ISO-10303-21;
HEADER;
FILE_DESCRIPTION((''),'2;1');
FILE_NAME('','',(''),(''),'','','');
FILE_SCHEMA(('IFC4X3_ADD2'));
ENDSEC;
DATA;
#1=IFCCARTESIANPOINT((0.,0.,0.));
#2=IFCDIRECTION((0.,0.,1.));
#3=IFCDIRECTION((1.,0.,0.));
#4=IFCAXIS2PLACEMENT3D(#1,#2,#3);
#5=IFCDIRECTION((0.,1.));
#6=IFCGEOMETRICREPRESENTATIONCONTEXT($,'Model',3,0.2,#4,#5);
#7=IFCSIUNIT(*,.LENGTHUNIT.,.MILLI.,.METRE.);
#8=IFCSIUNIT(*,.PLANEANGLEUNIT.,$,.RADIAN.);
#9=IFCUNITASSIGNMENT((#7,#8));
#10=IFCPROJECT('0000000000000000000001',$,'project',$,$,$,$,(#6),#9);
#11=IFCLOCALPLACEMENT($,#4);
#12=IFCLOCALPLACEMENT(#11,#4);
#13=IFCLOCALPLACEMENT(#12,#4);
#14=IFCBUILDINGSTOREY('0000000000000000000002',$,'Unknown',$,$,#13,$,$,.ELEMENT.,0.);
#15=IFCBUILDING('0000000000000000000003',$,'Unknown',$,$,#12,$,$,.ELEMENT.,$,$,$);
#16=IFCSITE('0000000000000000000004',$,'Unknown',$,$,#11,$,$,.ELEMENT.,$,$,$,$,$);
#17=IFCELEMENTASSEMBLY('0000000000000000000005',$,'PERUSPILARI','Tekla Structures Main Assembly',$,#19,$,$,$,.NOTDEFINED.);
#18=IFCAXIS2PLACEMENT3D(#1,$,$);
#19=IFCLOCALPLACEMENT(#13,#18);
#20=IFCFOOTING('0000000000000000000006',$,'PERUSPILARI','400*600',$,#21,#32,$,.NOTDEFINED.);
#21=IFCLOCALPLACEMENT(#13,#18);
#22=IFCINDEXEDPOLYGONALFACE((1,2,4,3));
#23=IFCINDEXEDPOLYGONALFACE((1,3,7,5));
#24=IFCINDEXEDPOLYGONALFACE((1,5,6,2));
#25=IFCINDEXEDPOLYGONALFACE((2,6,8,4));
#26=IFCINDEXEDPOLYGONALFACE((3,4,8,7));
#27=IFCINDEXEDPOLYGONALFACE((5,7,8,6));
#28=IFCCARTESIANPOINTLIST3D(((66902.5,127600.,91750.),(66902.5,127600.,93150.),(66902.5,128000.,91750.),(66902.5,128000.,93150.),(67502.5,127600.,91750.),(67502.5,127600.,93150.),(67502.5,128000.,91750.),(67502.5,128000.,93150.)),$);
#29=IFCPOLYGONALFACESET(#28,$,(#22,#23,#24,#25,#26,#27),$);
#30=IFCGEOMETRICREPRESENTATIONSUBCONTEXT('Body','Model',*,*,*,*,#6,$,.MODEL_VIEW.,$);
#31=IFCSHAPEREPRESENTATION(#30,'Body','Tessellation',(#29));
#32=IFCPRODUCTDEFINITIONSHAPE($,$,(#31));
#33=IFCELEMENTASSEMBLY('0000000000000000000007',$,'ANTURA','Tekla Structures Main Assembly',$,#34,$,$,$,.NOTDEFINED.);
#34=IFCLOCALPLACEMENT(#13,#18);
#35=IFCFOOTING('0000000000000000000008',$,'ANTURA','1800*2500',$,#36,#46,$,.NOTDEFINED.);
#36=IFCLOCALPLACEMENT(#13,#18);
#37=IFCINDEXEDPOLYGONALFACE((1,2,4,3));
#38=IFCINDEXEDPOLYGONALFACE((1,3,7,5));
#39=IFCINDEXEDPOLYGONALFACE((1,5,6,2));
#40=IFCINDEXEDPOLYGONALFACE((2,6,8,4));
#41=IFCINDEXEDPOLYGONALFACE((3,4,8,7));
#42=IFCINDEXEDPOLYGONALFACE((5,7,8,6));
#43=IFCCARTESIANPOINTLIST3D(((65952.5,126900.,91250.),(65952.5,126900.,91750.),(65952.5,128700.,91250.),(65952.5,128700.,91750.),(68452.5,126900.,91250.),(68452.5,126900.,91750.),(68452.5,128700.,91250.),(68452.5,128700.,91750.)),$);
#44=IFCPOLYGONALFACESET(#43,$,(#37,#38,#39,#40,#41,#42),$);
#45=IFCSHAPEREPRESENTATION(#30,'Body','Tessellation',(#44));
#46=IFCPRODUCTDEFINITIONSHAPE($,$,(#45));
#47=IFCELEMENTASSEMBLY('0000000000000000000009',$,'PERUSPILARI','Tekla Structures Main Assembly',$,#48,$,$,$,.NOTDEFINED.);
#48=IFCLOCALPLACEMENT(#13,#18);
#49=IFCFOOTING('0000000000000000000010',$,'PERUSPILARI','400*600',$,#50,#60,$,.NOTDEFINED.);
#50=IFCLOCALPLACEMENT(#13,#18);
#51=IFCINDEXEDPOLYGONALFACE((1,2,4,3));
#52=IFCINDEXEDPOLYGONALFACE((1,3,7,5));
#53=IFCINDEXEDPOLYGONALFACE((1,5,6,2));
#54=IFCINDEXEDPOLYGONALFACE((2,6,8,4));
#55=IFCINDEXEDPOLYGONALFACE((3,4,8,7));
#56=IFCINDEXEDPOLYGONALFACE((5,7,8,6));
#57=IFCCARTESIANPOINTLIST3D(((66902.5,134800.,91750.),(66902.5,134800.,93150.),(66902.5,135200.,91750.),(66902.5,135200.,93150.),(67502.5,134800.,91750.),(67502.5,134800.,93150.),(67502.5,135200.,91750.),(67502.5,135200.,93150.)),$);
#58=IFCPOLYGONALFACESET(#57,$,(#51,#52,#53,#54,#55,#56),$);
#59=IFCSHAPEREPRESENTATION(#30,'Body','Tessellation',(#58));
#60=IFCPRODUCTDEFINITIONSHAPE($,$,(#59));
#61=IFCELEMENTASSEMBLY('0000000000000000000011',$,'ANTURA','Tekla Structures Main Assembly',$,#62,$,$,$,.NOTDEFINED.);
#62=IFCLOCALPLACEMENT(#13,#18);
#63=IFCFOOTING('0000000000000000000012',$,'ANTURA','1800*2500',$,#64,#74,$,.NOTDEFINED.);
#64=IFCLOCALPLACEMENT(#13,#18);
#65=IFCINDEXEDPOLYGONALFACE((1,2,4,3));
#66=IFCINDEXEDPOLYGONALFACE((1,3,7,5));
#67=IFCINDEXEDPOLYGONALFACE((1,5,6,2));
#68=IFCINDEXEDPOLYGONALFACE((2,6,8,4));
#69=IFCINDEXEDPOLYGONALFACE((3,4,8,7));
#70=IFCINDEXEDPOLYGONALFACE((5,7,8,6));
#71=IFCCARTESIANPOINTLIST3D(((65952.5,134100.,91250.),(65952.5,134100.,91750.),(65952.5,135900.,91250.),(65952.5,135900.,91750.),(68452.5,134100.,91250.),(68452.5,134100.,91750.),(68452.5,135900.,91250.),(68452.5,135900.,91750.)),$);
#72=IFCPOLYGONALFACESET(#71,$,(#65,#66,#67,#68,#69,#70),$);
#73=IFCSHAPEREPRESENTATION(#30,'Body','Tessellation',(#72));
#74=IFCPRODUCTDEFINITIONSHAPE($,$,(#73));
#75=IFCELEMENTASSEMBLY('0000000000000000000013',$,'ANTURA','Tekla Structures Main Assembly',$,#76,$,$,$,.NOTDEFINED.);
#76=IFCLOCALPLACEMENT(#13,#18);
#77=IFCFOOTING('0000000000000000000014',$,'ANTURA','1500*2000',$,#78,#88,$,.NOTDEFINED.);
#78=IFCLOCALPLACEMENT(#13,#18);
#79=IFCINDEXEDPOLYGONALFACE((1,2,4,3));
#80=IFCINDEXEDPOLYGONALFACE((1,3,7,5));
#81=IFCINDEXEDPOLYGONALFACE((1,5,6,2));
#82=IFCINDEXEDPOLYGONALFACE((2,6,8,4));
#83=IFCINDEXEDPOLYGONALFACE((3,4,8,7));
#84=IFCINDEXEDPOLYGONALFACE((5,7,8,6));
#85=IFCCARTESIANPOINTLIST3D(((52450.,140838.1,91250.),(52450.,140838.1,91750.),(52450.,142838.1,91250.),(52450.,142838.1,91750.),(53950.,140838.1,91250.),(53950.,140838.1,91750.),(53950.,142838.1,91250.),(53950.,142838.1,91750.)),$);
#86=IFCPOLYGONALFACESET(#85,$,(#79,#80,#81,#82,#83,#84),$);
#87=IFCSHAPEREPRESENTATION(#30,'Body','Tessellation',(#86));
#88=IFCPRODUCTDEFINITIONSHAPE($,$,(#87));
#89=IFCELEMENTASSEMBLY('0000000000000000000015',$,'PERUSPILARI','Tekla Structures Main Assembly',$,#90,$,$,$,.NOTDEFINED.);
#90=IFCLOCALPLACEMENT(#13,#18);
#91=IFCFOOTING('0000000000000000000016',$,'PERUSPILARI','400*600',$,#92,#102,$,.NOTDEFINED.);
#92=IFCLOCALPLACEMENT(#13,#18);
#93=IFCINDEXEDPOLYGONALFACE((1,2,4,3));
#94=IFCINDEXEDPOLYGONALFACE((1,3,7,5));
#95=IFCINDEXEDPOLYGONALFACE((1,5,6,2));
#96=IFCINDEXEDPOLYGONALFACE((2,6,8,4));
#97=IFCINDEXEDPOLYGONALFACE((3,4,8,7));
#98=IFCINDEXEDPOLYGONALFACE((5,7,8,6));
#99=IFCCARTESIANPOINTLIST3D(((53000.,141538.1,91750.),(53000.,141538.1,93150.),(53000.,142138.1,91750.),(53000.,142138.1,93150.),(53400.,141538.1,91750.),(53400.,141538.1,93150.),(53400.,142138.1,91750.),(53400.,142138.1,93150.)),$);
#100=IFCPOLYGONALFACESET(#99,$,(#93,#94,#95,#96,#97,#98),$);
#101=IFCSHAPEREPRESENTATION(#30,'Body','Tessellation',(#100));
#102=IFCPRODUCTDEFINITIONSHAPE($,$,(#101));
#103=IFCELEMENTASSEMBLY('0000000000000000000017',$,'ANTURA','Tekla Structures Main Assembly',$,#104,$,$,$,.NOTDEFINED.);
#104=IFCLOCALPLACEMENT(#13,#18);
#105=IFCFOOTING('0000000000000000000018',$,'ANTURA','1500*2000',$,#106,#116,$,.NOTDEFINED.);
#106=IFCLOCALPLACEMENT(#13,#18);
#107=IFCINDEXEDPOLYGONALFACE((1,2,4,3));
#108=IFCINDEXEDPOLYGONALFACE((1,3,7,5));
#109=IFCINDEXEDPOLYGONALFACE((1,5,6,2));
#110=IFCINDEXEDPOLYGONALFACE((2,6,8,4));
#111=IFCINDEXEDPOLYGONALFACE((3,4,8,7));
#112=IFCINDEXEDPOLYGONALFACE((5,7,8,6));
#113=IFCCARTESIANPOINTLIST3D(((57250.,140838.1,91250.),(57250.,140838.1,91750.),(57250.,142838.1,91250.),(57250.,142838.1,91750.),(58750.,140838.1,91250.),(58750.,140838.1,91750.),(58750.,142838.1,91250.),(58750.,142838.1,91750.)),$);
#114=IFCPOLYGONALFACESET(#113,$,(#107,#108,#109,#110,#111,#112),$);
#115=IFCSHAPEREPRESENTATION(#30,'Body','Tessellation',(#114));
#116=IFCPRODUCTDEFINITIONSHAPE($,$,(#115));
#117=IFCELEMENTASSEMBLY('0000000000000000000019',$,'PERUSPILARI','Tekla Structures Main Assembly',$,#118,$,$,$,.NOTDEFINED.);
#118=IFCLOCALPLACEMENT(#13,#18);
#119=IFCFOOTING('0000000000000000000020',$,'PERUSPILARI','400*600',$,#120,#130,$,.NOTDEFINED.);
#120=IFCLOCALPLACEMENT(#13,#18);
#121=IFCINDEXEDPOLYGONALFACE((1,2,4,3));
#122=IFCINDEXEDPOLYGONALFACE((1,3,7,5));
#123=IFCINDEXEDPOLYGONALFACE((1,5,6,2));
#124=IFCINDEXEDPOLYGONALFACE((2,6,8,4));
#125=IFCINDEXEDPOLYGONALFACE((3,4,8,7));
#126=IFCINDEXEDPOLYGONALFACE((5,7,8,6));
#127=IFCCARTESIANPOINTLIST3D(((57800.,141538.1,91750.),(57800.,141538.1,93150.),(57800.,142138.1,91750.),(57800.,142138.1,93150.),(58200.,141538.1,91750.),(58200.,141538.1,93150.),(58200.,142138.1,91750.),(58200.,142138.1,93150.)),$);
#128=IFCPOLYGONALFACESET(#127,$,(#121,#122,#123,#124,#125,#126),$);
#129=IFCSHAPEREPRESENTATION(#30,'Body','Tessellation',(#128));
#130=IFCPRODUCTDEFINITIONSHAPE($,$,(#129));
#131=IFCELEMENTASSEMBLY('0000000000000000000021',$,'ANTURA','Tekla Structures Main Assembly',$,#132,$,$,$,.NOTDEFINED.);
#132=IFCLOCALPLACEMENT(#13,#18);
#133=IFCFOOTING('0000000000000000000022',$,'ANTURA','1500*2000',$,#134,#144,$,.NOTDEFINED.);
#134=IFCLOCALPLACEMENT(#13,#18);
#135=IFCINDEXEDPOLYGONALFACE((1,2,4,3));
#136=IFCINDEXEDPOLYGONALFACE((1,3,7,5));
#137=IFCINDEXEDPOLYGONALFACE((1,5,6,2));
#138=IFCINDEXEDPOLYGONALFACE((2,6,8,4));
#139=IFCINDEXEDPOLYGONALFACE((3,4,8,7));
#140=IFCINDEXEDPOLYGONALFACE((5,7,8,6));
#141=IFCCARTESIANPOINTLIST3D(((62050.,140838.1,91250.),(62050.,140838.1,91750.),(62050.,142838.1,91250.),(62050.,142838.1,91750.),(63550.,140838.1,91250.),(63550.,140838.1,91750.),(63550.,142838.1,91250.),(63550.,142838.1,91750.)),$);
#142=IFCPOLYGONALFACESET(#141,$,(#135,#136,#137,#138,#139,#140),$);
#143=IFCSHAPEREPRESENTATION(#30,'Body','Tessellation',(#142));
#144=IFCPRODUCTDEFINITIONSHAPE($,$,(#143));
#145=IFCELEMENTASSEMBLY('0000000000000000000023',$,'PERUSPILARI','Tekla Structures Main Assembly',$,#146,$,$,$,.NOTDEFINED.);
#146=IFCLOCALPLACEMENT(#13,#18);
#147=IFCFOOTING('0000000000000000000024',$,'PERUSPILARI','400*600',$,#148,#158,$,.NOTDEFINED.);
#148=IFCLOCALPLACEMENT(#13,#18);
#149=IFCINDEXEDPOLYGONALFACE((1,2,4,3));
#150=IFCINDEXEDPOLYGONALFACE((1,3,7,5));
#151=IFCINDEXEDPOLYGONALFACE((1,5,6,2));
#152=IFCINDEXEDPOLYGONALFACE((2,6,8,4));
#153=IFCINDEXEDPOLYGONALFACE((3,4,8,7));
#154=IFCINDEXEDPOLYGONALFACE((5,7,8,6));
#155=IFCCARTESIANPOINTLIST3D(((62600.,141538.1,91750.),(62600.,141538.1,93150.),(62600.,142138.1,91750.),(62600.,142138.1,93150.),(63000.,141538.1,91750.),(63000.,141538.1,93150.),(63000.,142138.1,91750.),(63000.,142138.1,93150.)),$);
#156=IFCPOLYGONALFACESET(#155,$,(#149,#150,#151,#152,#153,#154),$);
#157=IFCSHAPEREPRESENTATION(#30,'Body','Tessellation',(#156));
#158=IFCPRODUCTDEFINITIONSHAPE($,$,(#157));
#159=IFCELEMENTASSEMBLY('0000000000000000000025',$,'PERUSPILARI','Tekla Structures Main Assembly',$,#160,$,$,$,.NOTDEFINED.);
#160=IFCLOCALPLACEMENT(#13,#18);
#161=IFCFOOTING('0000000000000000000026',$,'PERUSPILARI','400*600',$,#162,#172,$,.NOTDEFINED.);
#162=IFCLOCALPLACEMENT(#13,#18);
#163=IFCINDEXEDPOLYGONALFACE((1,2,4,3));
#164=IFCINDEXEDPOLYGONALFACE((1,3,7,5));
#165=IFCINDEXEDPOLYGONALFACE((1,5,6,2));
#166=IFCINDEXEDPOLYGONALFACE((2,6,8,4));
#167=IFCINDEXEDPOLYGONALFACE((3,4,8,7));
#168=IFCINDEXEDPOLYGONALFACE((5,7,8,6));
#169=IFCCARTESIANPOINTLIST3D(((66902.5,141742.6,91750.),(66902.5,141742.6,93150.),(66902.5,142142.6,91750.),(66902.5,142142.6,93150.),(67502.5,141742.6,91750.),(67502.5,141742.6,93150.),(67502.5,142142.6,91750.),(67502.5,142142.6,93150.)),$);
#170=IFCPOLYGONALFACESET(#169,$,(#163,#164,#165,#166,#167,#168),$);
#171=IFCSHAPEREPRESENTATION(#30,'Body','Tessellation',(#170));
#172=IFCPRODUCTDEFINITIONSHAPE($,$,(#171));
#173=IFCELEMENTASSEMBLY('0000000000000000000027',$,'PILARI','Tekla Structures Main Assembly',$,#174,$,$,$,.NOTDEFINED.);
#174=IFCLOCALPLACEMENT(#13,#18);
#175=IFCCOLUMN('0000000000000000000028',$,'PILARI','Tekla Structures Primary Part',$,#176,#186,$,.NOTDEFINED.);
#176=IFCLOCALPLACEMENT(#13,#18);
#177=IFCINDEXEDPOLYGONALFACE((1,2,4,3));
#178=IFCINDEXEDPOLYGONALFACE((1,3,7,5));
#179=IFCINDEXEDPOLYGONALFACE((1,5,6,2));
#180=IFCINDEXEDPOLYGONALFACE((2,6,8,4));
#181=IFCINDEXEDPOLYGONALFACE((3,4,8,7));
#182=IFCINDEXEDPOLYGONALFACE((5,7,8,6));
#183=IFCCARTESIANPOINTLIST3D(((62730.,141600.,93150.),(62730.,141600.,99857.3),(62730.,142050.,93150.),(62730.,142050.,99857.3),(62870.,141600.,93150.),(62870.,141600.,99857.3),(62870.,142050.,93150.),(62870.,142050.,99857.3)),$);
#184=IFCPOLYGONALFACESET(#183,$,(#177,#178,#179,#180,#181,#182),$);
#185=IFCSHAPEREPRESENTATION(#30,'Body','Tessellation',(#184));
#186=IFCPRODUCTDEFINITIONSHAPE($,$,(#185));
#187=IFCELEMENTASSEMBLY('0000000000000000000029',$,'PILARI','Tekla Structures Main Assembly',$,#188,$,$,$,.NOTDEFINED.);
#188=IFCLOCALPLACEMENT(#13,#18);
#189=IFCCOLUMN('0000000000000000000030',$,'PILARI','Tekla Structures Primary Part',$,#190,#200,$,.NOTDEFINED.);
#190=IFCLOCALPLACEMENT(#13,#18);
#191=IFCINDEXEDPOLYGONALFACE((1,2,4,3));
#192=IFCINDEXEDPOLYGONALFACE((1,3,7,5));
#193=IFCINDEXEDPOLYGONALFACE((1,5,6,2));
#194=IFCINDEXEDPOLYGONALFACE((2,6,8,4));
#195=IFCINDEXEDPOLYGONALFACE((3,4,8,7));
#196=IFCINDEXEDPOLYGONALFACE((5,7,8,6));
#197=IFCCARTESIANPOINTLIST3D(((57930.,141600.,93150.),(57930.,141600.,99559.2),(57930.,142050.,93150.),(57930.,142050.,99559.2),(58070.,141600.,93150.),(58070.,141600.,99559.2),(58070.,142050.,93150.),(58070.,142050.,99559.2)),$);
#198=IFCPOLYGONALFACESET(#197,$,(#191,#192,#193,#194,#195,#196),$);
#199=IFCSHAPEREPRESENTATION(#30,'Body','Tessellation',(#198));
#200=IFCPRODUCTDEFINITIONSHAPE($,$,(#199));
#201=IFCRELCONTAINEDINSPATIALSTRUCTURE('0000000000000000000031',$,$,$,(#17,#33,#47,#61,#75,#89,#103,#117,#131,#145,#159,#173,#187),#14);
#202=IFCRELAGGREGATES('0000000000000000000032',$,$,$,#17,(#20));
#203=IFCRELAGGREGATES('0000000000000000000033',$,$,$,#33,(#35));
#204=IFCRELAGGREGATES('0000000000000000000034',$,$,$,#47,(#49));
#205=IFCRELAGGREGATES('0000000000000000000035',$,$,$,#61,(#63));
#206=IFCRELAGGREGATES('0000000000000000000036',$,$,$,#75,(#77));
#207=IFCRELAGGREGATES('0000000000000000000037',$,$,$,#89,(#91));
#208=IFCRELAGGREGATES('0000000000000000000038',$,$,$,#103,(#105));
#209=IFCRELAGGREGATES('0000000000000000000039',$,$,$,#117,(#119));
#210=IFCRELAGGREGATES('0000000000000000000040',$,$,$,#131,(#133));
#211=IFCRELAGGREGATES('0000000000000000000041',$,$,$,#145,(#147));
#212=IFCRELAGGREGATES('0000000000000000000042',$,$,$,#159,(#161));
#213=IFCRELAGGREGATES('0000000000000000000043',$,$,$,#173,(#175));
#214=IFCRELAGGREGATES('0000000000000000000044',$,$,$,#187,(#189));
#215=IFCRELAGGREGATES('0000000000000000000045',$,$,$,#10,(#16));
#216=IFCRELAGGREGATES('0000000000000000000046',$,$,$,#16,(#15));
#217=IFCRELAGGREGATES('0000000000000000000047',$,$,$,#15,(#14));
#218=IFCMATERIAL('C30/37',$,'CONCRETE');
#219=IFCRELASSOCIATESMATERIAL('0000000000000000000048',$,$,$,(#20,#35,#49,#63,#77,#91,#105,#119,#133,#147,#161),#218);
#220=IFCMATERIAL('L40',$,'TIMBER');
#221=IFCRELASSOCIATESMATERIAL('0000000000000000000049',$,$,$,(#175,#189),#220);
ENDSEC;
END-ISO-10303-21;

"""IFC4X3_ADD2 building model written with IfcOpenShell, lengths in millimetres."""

from ifc_helpers import new_model, si_unit, direction, frame, origin_with_axes, place, context, subcontext, project, spatial, line, indexed_curve, outline, extrude, material, element, aggregate, save


model = new_model("IFC4X3_ADD2")

# Units and contexts
model_context = context("Model", 3, precision=0.2, world=origin_with_axes(), true_north=direction((0.0, 1.0)))
body_context = subcontext(model_context, "Body", "Model", "MODEL_VIEW")
ifc_project = project(units=[si_unit("LENGTHUNIT", "METRE", prefix="MILLI"), si_unit("PLANEANGLEUNIT", "RADIAN")], contexts=[model_context])

# Site, building, storey
site_placement = place(None, origin_with_axes())
site = spatial("IfcSite", under=ifc_project, at=site_placement, Name="Unknown", CompositionType="ELEMENT")
building_placement = place(site_placement, origin_with_axes())
building = spatial("IfcBuilding", under=site, at=building_placement, Name="Unknown", CompositionType="ELEMENT")
storey_placement = place(building_placement, origin_with_axes())
storey = spatial("IfcBuildingStorey", under=building, at=storey_placement, Name="Unknown", CompositionType="ELEMENT", Elevation=0.0)

# Element assembly, footing
assembly_1_placement = place(storey_placement, frame((67202.5, 127800.0, 91750.0), z_axis=(-1.0, 0.0, 0.0), x_axis=(0.0, 0.0, 1.0)))
assembly_1 = element("IfcElementAssembly", 1, at=assembly_1_placement, inside=storey, Name="PERUSPILARI", Description="Tekla Structures Main Assembly", PredefinedType="NOTDEFINED")
ifc_material_1 = material(Name="C30/37", Category="CONCRETE")
footing_1_placement = place(assembly_1_placement, origin_with_axes())
footing_1 = element("IfcFooting", 2, at=footing_1_placement, material=ifc_material_1, Name="PERUSPILARI", Description="400*600", PredefinedType="NOTDEFINED", context=body_context, shape_type="SolidModel", body=[
    extrude(outline(indexed_curve([(-300.0, -200.0), (300.0, -200.0), (300.0, 200.0), (-300.0, 200.0)], segments=[line(1, 2, 3, 4, 1)])), frame((0.0, 0.0, 0.0), z_axis=(-1.0, 0.0, 0.0), x_axis=(0.0, 0.0, 1.0)), (0.0, 0.0, -1.0), 1400.0),
])
aggregate(assembly_1, [footing_1])

# Element assembly, footing
assembly_2_placement = place(storey_placement, frame((67202.5, 127800.0, 91250.0), z_axis=(-1.0, 0.0, 0.0), x_axis=(0.0, 0.0, 1.0)))
assembly_2 = element("IfcElementAssembly", 3, at=assembly_2_placement, inside=storey, Name="ANTURA", Description="Tekla Structures Main Assembly", PredefinedType="NOTDEFINED")
footing_2_placement = place(assembly_2_placement, origin_with_axes())
footing_2 = element("IfcFooting", 4, at=footing_2_placement, material=ifc_material_1, Name="ANTURA", Description="1800*2500", PredefinedType="NOTDEFINED", context=body_context, shape_type="SolidModel", body=[
    extrude(outline(indexed_curve([(-1250.0, -900.0), (1250.0, -900.0), (1250.0, 900.0), (-1250.0, 900.0)], segments=[line(1, 2, 3, 4, 1)])), frame((0.0, 0.0, 0.0), z_axis=(-1.0, 0.0, 0.0), x_axis=(0.0, 0.0, 1.0)), (0.0, 0.0, -1.0), 500.0),
])
aggregate(assembly_2, [footing_2])

# Element assembly, footing
assembly_3_placement = place(storey_placement, frame((67202.5, 135000.0, 91750.0), z_axis=(-1.0, 0.0, 0.0), x_axis=(0.0, 0.0, 1.0)))
assembly_3 = element("IfcElementAssembly", 5, at=assembly_3_placement, inside=storey, Name="PERUSPILARI", Description="Tekla Structures Main Assembly", PredefinedType="NOTDEFINED")
footing_3_placement = place(assembly_3_placement, origin_with_axes())
footing_3 = element("IfcFooting", 6, at=footing_3_placement, material=ifc_material_1, Name="PERUSPILARI", Description="400*600", PredefinedType="NOTDEFINED", context=body_context, shape_type="SolidModel", body=[
    extrude(outline(indexed_curve([(-300.0, -200.0), (300.0, -200.0), (300.0, 200.0), (-300.0, 200.0)], segments=[line(1, 2, 3, 4, 1)])), frame((0.0, 0.0, 0.0), z_axis=(-1.0, 0.0, 0.0), x_axis=(0.0, 0.0, 1.0)), (0.0, 0.0, -1.0), 1400.0),
])
aggregate(assembly_3, [footing_3])

# Element assembly, footing
assembly_4_placement = place(storey_placement, frame((67202.5, 135000.0, 91250.0), z_axis=(-1.0, 0.0, 0.0), x_axis=(0.0, 0.0, 1.0)))
assembly_4 = element("IfcElementAssembly", 7, at=assembly_4_placement, inside=storey, Name="ANTURA", Description="Tekla Structures Main Assembly", PredefinedType="NOTDEFINED")
footing_4_placement = place(assembly_4_placement, origin_with_axes())
footing_4 = element("IfcFooting", 8, at=footing_4_placement, material=ifc_material_1, Name="ANTURA", Description="1800*2500", PredefinedType="NOTDEFINED", context=body_context, shape_type="SolidModel", body=[
    extrude(outline(indexed_curve([(-1250.0, -900.0), (1250.0, -900.0), (1250.0, 900.0), (-1250.0, 900.0)], segments=[line(1, 2, 3, 4, 1)])), frame((0.0, 0.0, 0.0), z_axis=(-1.0, 0.0, 0.0), x_axis=(0.0, 0.0, 1.0)), (0.0, 0.0, -1.0), 500.0),
])
aggregate(assembly_4, [footing_4])

# Element assemblies, footings
assembly_5_placement = place(storey_placement, frame((53200.0, 141838.1, 91250.0), z_axis=(0.0, -1.0, 0.0), x_axis=(0.0, 0.0, 1.0)))
assembly_5 = element("IfcElementAssembly", 9, at=assembly_5_placement, inside=storey, Name="ANTURA", Description="Tekla Structures Main Assembly", PredefinedType="NOTDEFINED")
footing_5_placement = place(assembly_5_placement, origin_with_axes())
footing_5 = element("IfcFooting", 10, at=footing_5_placement, material=ifc_material_1, Name="ANTURA", Description="1500*2000", PredefinedType="NOTDEFINED", context=body_context, shape_type="SolidModel", body=[
    extrude(outline(indexed_curve([(-1000.0, -750.0), (1000.0, -750.0), (1000.0, 750.0), (-1000.0, 750.0)], segments=[line(1, 2, 3, 4, 1)])), frame((0.0, 0.0, 0.0), z_axis=(-1.0, 0.0, 0.0), x_axis=(0.0, 0.0, 1.0)), (0.0, 0.0, -1.0), 500.0),
])
aggregate(assembly_5, [footing_5])
assembly_6_placement = place(storey_placement, frame((53200.0, 141838.1, 91750.0), z_axis=(0.0, -1.0, 0.0), x_axis=(0.0, 0.0, 1.0)))
assembly_6 = element("IfcElementAssembly", 11, at=assembly_6_placement, inside=storey, Name="PERUSPILARI", Description="Tekla Structures Main Assembly", PredefinedType="NOTDEFINED")
footing_6_placement = place(assembly_6_placement, origin_with_axes())
footing_6 = element("IfcFooting", 12, at=footing_6_placement, material=ifc_material_1, Name="PERUSPILARI", Description="400*600", PredefinedType="NOTDEFINED", context=body_context, shape_type="SolidModel", body=[
    extrude(outline(indexed_curve([(-300.0, -200.0), (300.0, -200.0), (300.0, 200.0), (-300.0, 200.0)], segments=[line(1, 2, 3, 4, 1)])), frame((0.0, 0.0, 0.0), z_axis=(-1.0, 0.0, 0.0), x_axis=(0.0, 0.0, 1.0)), (0.0, 0.0, -1.0), 1400.0),
])
aggregate(assembly_6, [footing_6])
assembly_7_placement = place(storey_placement, frame((58000.0, 141838.1, 91250.0), z_axis=(0.0, -1.0, 0.0), x_axis=(0.0, 0.0, 1.0)))
assembly_7 = element("IfcElementAssembly", 13, at=assembly_7_placement, inside=storey, Name="ANTURA", Description="Tekla Structures Main Assembly", PredefinedType="NOTDEFINED")
footing_7_placement = place(assembly_7_placement, origin_with_axes())
footing_7 = element("IfcFooting", 14, at=footing_7_placement, material=ifc_material_1, Name="ANTURA", Description="1500*2000", PredefinedType="NOTDEFINED", context=body_context, shape_type="SolidModel", body=[
    extrude(outline(indexed_curve([(-1000.0, -750.0), (1000.0, -750.0), (1000.0, 750.0), (-1000.0, 750.0)], segments=[line(1, 2, 3, 4, 1)])), frame((0.0, 0.0, 0.0), z_axis=(-1.0, 0.0, 0.0), x_axis=(0.0, 0.0, 1.0)), (0.0, 0.0, -1.0), 500.0),
])
aggregate(assembly_7, [footing_7])
assembly_8_placement = place(storey_placement, frame((58000.0, 141838.1, 91750.0), z_axis=(0.0, -1.0, 0.0), x_axis=(0.0, 0.0, 1.0)))
assembly_8 = element("IfcElementAssembly", 15, at=assembly_8_placement, inside=storey, Name="PERUSPILARI", Description="Tekla Structures Main Assembly", PredefinedType="NOTDEFINED")
footing_8_placement = place(assembly_8_placement, origin_with_axes())
footing_8 = element("IfcFooting", 16, at=footing_8_placement, material=ifc_material_1, Name="PERUSPILARI", Description="400*600", PredefinedType="NOTDEFINED", context=body_context, shape_type="SolidModel", body=[
    extrude(outline(indexed_curve([(-300.0, -200.0), (300.0, -200.0), (300.0, 200.0), (-300.0, 200.0)], segments=[line(1, 2, 3, 4, 1)])), frame((0.0, 0.0, 0.0), z_axis=(-1.0, 0.0, 0.0), x_axis=(0.0, 0.0, 1.0)), (0.0, 0.0, -1.0), 1400.0),
])
aggregate(assembly_8, [footing_8])
assembly_9_placement = place(storey_placement, frame((62800.0, 141838.1, 91250.0), z_axis=(0.0, -1.0, 0.0), x_axis=(0.0, 0.0, 1.0)))
assembly_9 = element("IfcElementAssembly", 17, at=assembly_9_placement, inside=storey, Name="ANTURA", Description="Tekla Structures Main Assembly", PredefinedType="NOTDEFINED")
footing_9_placement = place(assembly_9_placement, origin_with_axes())
footing_9 = element("IfcFooting", 18, at=footing_9_placement, material=ifc_material_1, Name="ANTURA", Description="1500*2000", PredefinedType="NOTDEFINED", context=body_context, shape_type="SolidModel", body=[
    extrude(outline(indexed_curve([(-1000.0, -750.0), (1000.0, -750.0), (1000.0, 750.0), (-1000.0, 750.0)], segments=[line(1, 2, 3, 4, 1)])), frame((0.0, 0.0, 0.0), z_axis=(-1.0, 0.0, 0.0), x_axis=(0.0, 0.0, 1.0)), (0.0, 0.0, -1.0), 500.0),
])
aggregate(assembly_9, [footing_9])
assembly_10_placement = place(storey_placement, frame((62800.0, 141838.1, 91750.0), z_axis=(0.0, -1.0, 0.0), x_axis=(0.0, 0.0, 1.0)))
assembly_10 = element("IfcElementAssembly", 19, at=assembly_10_placement, inside=storey, Name="PERUSPILARI", Description="Tekla Structures Main Assembly", PredefinedType="NOTDEFINED")
footing_10_placement = place(assembly_10_placement, origin_with_axes())
footing_10 = element("IfcFooting", 20, at=footing_10_placement, material=ifc_material_1, Name="PERUSPILARI", Description="400*600", PredefinedType="NOTDEFINED", context=body_context, shape_type="SolidModel", body=[
    extrude(outline(indexed_curve([(-300.0, -200.0), (300.0, -200.0), (300.0, 200.0), (-300.0, 200.0)], segments=[line(1, 2, 3, 4, 1)])), frame((0.0, 0.0, 0.0), z_axis=(-1.0, 0.0, 0.0), x_axis=(0.0, 0.0, 1.0)), (0.0, 0.0, -1.0), 1400.0),
])
aggregate(assembly_10, [footing_10])
assembly_11_placement = place(storey_placement, frame((67202.5, 141942.6, 91750.0), z_axis=(-1.0, 0.0, 0.0), x_axis=(0.0, 0.0, 1.0)))
assembly_11 = element("IfcElementAssembly", 21, at=assembly_11_placement, inside=storey, Name="PERUSPILARI", Description="Tekla Structures Main Assembly", PredefinedType="NOTDEFINED")
footing_11_placement = place(assembly_11_placement, origin_with_axes())
footing_11 = element("IfcFooting", 22, at=footing_11_placement, material=ifc_material_1, Name="PERUSPILARI", Description="400*600", PredefinedType="NOTDEFINED", context=body_context, shape_type="SolidModel", body=[
    extrude(outline(indexed_curve([(-300.0, -200.0), (300.0, -200.0), (300.0, 200.0), (-300.0, 200.0)], segments=[line(1, 2, 3, 4, 1)])), frame((0.0, 0.0, 0.0), z_axis=(-1.0, 0.0, 0.0), x_axis=(0.0, 0.0, 1.0)), (0.0, 0.0, -1.0), 1400.0),
])
aggregate(assembly_11, [footing_11])

# Element assemblies, columns
assembly_12_placement = place(storey_placement, frame((62800.0, 141825.0, 93150.0), z_axis=(0.0, -1.0, 0.0), x_axis=(0.0, 0.0, 1.0)))
assembly_12 = element("IfcElementAssembly", 23, at=assembly_12_placement, inside=storey, Name="PILARI", Description="Tekla Structures Main Assembly", PredefinedType="NOTDEFINED")
ifc_material_2 = material(Name="L40", Category="TIMBER")
column_1_placement = place(assembly_12_placement, origin_with_axes())
column_1 = element("IfcColumn", 24, at=column_1_placement, material=ifc_material_2, Name="PILARI", Description="Tekla Structures Primary Part", PredefinedType="NOTDEFINED", context=body_context, shape_type="SolidModel", body=[
    extrude(outline(indexed_curve([(-225.0, -70.0), (225.0, -70.0), (225.0, 70.0), (-225.0, 70.0)], segments=[line(1, 2, 3, 4, 1)])), frame((0.0, 0.0, 0.0), z_axis=(-1.0, 0.0, 0.0), x_axis=(0.0, 0.0, 1.0)), (0.0, 0.0, -1.0), 6707.3),
])
aggregate(assembly_12, [column_1])
assembly_13_placement = place(storey_placement, frame((58000.0, 141825.0, 93150.0), z_axis=(0.0, -1.0, 0.0), x_axis=(0.0, 0.0, 1.0)))
assembly_13 = element("IfcElementAssembly", 25, at=assembly_13_placement, inside=storey, Name="PILARI", Description="Tekla Structures Main Assembly", PredefinedType="NOTDEFINED")
column_2_placement = place(assembly_13_placement, origin_with_axes())
column_2 = element("IfcColumn", 26, at=column_2_placement, material=ifc_material_2, Name="PILARI", Description="Tekla Structures Primary Part", PredefinedType="NOTDEFINED", context=body_context, shape_type="SolidModel", body=[
    extrude(outline(indexed_curve([(-225.0, -70.0), (225.0, -70.0), (225.0, 70.0), (-225.0, 70.0)], segments=[line(1, 2, 3, 4, 1)])), frame((0.0, 0.0, 0.0), z_axis=(-1.0, 0.0, 0.0), x_axis=(0.0, 0.0, 1.0)), (0.0, 0.0, -1.0), 6409.2),
])
aggregate(assembly_13, [column_2])

save(model, "model.ifc")
